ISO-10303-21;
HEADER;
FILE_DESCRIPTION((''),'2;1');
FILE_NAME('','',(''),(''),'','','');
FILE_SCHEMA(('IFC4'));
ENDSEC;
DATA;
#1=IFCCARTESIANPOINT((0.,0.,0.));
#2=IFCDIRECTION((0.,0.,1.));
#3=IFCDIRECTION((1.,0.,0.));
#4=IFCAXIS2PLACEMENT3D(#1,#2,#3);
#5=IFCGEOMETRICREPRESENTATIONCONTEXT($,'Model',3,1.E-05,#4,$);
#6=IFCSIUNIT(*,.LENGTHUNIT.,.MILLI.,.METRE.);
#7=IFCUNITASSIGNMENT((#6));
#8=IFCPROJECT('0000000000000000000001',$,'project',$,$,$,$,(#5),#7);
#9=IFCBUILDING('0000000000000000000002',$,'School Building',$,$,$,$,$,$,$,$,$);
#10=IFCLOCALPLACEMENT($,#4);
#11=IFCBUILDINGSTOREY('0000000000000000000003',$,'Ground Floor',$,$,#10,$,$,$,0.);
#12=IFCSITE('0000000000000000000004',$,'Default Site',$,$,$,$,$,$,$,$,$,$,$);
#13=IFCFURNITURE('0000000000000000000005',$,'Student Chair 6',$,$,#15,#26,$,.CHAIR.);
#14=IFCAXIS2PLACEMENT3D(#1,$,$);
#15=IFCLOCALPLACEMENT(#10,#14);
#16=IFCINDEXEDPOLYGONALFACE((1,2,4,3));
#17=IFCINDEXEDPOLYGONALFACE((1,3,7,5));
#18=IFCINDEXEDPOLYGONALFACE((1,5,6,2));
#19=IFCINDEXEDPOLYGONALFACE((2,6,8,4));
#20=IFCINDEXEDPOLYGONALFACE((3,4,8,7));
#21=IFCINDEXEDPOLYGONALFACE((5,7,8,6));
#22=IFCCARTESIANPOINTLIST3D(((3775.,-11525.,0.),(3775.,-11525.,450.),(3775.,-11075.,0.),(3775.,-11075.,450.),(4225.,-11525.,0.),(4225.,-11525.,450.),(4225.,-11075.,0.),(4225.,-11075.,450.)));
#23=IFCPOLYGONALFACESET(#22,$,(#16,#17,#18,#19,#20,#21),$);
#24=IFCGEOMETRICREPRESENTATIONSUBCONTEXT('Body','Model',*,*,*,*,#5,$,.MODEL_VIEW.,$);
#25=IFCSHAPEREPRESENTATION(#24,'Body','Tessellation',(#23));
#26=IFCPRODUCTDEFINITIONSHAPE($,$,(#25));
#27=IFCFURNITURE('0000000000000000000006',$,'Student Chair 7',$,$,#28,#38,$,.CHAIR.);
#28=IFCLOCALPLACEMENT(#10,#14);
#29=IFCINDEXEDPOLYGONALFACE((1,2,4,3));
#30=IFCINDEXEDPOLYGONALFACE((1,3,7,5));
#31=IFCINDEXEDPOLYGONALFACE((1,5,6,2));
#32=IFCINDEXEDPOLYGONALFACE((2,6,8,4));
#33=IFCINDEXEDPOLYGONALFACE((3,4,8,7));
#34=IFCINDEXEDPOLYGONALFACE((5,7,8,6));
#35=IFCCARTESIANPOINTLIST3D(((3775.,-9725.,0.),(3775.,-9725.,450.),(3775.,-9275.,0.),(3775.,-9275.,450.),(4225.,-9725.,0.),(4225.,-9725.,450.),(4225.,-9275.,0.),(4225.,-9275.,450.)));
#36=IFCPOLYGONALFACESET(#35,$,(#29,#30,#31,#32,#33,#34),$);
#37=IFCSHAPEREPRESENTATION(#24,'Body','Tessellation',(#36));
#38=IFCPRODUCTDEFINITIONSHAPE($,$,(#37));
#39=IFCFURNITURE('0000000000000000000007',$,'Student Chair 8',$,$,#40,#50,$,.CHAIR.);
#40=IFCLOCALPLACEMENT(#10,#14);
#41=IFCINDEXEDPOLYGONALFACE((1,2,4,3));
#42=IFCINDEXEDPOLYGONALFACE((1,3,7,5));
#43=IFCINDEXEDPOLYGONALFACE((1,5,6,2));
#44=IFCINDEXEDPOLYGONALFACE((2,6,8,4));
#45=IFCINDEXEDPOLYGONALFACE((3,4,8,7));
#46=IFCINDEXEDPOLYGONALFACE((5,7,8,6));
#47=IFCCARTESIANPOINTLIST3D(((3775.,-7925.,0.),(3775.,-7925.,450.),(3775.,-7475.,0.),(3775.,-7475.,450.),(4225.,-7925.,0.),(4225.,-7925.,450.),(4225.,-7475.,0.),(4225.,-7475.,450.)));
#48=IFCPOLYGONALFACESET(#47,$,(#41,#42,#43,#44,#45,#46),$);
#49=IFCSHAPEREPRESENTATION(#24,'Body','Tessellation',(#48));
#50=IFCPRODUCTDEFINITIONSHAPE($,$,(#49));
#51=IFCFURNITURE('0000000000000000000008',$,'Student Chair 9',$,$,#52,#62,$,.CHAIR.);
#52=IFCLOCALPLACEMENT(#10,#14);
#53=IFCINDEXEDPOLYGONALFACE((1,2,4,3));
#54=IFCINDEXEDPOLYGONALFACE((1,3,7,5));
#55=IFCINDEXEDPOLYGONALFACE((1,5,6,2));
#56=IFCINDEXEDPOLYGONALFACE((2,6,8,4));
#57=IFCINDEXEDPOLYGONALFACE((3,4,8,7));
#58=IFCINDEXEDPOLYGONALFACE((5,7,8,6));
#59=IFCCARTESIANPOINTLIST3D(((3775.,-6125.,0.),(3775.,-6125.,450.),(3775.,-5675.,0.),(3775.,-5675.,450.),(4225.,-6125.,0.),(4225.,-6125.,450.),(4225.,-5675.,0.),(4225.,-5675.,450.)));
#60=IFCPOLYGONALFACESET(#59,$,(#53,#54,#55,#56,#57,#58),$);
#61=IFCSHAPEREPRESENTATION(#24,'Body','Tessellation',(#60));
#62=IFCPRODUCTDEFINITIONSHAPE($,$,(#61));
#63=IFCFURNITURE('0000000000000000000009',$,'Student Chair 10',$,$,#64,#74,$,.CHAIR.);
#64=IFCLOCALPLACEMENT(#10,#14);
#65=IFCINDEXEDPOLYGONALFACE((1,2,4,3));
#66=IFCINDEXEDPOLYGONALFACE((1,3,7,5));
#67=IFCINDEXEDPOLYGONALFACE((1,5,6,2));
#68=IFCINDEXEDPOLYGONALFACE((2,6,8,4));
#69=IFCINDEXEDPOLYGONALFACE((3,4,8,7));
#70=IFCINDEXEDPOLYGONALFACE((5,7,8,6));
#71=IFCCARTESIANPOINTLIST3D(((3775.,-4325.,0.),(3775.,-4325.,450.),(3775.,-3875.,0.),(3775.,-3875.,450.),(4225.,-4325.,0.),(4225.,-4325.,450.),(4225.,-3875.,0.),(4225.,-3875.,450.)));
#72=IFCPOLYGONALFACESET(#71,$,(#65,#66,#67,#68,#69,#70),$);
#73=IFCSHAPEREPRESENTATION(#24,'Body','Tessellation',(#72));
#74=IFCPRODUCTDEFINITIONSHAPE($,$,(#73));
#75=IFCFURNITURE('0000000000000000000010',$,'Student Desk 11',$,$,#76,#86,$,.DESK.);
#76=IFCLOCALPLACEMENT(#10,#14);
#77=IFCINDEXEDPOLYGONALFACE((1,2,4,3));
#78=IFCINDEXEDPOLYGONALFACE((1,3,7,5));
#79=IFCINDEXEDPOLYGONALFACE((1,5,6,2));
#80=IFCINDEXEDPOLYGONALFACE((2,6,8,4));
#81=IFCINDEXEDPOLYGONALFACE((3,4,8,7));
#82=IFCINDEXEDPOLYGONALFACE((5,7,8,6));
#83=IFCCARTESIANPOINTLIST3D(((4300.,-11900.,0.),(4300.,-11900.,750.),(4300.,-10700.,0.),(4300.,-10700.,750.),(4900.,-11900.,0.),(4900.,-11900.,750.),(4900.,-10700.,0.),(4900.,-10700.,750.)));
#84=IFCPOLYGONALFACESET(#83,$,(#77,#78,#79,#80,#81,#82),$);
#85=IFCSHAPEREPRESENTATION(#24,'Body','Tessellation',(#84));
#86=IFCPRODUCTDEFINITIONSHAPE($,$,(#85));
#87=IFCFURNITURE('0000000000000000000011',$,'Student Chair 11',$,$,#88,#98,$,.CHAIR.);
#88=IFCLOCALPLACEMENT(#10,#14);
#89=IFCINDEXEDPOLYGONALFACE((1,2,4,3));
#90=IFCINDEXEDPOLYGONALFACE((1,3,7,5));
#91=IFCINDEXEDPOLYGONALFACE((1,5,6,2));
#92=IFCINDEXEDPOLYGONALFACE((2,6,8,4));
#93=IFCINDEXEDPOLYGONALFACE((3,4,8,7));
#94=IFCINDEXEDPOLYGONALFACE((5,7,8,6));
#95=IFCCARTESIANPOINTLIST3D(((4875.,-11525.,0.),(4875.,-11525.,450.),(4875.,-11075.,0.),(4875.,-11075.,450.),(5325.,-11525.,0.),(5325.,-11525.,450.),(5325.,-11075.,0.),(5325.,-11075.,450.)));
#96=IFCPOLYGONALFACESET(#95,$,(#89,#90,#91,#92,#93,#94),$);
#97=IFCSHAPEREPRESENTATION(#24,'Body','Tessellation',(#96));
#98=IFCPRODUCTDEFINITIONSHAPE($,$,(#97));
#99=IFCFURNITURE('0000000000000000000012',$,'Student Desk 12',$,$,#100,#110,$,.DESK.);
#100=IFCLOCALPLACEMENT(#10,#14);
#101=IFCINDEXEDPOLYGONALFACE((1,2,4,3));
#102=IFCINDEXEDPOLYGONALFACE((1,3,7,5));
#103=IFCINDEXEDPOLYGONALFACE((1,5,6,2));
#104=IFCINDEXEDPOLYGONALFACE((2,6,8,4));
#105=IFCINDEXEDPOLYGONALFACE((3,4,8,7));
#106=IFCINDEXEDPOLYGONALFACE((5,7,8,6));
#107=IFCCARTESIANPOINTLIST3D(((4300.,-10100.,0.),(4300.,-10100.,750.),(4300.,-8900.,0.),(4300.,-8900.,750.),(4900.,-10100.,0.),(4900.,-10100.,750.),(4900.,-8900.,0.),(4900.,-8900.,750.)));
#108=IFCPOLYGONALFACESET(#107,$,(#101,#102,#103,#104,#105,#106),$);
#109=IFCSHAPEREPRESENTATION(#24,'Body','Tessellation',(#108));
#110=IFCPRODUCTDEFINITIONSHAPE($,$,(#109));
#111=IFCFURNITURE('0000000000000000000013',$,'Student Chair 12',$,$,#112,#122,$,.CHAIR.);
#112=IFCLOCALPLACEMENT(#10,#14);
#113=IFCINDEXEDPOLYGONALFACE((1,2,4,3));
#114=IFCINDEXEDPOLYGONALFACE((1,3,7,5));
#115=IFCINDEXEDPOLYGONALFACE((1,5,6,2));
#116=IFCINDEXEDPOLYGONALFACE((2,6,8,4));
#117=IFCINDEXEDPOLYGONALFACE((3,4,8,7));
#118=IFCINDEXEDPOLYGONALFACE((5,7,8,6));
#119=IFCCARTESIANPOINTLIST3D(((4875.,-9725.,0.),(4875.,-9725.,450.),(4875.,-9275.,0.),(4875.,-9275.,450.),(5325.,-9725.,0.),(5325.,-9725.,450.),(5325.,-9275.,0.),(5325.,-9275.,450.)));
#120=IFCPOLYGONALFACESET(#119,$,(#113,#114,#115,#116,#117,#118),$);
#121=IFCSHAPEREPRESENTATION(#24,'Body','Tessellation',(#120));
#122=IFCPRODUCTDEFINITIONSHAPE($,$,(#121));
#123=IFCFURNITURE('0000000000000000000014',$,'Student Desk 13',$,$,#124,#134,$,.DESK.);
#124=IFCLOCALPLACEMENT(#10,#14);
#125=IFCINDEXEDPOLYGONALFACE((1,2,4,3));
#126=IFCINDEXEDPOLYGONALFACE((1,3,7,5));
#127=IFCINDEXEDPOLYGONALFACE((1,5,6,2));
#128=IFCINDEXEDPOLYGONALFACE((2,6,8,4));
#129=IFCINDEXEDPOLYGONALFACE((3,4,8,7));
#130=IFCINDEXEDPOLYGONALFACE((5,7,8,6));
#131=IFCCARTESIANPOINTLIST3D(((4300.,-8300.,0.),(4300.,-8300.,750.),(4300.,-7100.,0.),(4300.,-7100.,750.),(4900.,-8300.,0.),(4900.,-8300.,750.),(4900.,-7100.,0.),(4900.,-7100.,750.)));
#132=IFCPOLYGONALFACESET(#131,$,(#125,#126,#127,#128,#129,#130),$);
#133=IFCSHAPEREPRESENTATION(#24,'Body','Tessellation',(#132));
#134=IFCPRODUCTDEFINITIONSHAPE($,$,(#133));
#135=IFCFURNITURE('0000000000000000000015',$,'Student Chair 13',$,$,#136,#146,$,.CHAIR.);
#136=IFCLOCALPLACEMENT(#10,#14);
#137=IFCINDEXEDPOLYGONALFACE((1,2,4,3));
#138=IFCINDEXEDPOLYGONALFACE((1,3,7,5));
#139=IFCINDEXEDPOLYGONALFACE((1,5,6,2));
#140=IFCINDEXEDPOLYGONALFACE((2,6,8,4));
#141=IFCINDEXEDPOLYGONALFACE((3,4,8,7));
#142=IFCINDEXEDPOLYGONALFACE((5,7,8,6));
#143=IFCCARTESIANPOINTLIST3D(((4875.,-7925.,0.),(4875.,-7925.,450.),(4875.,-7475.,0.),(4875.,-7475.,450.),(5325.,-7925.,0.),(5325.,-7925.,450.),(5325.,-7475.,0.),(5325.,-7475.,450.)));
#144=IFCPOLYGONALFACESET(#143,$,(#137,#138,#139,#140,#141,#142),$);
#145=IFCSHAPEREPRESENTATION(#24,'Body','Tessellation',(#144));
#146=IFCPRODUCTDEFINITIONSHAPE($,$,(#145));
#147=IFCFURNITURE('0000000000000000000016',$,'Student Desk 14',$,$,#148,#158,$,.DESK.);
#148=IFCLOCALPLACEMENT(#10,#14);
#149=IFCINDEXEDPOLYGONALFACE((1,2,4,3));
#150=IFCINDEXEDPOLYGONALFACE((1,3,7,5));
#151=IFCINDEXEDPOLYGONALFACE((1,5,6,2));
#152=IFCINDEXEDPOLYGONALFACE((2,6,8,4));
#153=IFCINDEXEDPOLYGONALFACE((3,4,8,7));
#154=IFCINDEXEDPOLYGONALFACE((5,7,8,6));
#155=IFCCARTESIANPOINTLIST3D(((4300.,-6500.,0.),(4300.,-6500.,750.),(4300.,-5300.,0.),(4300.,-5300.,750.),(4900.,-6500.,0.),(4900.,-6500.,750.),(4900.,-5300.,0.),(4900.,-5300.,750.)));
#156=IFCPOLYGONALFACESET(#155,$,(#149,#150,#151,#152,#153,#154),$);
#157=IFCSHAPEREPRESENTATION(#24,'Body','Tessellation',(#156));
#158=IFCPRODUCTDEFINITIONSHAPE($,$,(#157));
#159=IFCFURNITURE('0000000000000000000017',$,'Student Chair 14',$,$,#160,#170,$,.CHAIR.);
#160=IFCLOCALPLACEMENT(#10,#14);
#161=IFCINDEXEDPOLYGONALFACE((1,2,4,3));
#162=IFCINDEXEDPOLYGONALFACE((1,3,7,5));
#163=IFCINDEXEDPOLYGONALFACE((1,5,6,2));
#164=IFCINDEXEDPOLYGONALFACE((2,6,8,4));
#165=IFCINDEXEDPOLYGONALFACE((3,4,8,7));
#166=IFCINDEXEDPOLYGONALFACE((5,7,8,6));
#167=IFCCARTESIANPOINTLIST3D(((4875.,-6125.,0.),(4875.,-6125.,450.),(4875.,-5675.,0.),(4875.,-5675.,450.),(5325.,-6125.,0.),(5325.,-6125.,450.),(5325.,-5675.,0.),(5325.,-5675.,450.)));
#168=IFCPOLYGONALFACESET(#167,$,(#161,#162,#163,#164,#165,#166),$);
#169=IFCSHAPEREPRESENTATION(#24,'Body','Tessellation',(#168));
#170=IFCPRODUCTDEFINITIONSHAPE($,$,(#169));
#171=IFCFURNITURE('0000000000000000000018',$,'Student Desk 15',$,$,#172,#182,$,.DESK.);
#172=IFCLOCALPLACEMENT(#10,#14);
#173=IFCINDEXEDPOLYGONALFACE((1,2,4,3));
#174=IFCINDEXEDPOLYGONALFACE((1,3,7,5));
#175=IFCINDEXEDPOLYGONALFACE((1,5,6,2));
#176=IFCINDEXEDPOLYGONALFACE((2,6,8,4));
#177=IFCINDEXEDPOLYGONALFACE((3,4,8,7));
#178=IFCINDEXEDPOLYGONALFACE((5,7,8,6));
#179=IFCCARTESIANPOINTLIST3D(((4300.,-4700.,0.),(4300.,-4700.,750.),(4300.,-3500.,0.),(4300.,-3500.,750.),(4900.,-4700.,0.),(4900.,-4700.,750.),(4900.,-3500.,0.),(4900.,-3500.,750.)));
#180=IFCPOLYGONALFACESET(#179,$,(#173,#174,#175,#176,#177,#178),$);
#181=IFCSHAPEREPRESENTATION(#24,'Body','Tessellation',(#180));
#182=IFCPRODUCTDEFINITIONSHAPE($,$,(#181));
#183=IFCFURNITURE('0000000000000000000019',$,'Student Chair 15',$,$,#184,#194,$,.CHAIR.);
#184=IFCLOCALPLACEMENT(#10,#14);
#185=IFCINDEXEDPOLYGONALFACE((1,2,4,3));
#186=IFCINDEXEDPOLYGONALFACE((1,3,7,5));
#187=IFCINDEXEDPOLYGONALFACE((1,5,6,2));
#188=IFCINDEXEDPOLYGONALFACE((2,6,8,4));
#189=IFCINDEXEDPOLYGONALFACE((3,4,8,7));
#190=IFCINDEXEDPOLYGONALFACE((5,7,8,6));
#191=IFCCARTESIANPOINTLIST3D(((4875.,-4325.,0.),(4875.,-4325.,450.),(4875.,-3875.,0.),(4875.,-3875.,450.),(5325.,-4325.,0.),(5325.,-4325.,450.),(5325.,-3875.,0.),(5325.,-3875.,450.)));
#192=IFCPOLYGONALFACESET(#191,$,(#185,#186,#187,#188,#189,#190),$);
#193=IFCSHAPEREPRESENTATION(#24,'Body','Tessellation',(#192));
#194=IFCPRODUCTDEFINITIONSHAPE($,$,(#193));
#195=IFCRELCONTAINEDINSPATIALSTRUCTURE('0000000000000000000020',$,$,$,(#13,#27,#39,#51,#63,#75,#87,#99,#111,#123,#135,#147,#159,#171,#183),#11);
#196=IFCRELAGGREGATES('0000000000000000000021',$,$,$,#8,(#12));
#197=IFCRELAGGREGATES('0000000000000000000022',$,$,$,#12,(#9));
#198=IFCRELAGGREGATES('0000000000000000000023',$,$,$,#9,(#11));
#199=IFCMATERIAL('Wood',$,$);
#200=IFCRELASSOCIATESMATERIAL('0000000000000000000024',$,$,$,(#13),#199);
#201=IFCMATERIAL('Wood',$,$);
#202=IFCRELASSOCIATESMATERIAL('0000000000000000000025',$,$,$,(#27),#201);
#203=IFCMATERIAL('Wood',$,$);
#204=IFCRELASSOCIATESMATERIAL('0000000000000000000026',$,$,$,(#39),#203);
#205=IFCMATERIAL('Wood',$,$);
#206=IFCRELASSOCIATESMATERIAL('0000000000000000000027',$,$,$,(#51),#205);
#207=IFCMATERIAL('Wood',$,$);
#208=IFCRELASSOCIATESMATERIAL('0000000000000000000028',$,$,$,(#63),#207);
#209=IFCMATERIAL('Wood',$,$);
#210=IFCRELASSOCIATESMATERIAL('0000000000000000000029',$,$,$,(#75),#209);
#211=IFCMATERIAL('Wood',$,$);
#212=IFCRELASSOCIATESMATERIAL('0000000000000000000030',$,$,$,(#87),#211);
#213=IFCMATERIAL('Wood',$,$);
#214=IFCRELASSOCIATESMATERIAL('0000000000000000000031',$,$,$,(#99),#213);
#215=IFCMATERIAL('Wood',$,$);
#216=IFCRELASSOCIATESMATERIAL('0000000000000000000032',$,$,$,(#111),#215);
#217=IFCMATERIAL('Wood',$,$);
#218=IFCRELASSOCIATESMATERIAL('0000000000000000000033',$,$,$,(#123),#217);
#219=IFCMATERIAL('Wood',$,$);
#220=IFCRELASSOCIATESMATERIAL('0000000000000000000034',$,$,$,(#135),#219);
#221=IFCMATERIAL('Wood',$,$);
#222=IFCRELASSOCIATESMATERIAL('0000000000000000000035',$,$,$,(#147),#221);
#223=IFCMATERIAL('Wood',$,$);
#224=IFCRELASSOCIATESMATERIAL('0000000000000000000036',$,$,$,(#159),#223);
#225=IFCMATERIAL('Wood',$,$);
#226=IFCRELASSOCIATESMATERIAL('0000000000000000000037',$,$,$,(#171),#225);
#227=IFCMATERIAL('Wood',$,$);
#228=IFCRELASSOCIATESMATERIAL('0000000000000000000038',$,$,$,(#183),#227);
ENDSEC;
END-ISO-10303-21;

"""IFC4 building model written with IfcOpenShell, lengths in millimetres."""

from ifc_helpers import new_model, si_unit, frame, origin_with_axes, origin_2d, place, context, subcontext, project, spatial, rectangle, extrude, material, element, save


model = new_model("IFC4")

# Units and contexts
model_context = context("Model", 3, precision=1e-05, world=origin_with_axes())
body_context = subcontext(model_context, "Body", "Model", "MODEL_VIEW")
ifc_project = project(units=[si_unit("LENGTHUNIT", "METRE", prefix="MILLI")], contexts=[model_context])

# Site, building, storey
site = spatial("IfcSite", under=ifc_project, Name="Default Site")
building = spatial("IfcBuilding", under=site, Name="School Building")
storey_placement = place(None, origin_with_axes())
storey = spatial("IfcBuildingStorey", under=building, at=storey_placement, Name="Ground Floor", Elevation=0.0)

# Furniture
ifc_material_1 = material(Name="Wood")
furniture_1_placement = place(storey_placement, frame((4000.0, -11300.0, 0.0), z_axis=(0.0, 0.0, 1.0), x_axis=(1.0, 0.0, 0.0)))
element("IfcFurniture", 1, at=furniture_1_placement, inside=storey, material=ifc_material_1, Name="Student Chair 6", PredefinedType="CHAIR", context=body_context, shape_type="SweptSolid", body=[
    extrude(rectangle(XDim=450.0, YDim=450.0, at=origin_2d()), origin_with_axes(), (0.0, 0.0, 1.0), 450.0),
])
ifc_material_2 = material(Name="Wood")
furniture_2_placement = place(storey_placement, frame((4000.0, -9500.0, 0.0), z_axis=(0.0, 0.0, 1.0), x_axis=(1.0, 0.0, 0.0)))
element("IfcFurniture", 2, at=furniture_2_placement, inside=storey, material=ifc_material_2, Name="Student Chair 7", PredefinedType="CHAIR", context=body_context, shape_type="SweptSolid", body=[
    extrude(rectangle(XDim=450.0, YDim=450.0, at=origin_2d()), origin_with_axes(), (0.0, 0.0, 1.0), 450.0),
])
ifc_material_3 = material(Name="Wood")
furniture_3_placement = place(storey_placement, frame((4000.0, -7700.0, 0.0), z_axis=(0.0, 0.0, 1.0), x_axis=(1.0, 0.0, 0.0)))
element("IfcFurniture", 3, at=furniture_3_placement, inside=storey, material=ifc_material_3, Name="Student Chair 8", PredefinedType="CHAIR", context=body_context, shape_type="SweptSolid", body=[
    extrude(rectangle(XDim=450.0, YDim=450.0, at=origin_2d()), origin_with_axes(), (0.0, 0.0, 1.0), 450.0),
])
ifc_material_4 = material(Name="Wood")
furniture_4_placement = place(storey_placement, frame((4000.0, -5900.0, 0.0), z_axis=(0.0, 0.0, 1.0), x_axis=(1.0, 0.0, 0.0)))
element("IfcFurniture", 4, at=furniture_4_placement, inside=storey, material=ifc_material_4, Name="Student Chair 9", PredefinedType="CHAIR", context=body_context, shape_type="SweptSolid", body=[
    extrude(rectangle(XDim=450.0, YDim=450.0, at=origin_2d()), origin_with_axes(), (0.0, 0.0, 1.0), 450.0),
])
ifc_material_5 = material(Name="Wood")
furniture_5_placement = place(storey_placement, frame((4000.0, -4100.0, 0.0), z_axis=(0.0, 0.0, 1.0), x_axis=(1.0, 0.0, 0.0)))
element("IfcFurniture", 5, at=furniture_5_placement, inside=storey, material=ifc_material_5, Name="Student Chair 10", PredefinedType="CHAIR", context=body_context, shape_type="SweptSolid", body=[
    extrude(rectangle(XDim=450.0, YDim=450.0, at=origin_2d()), origin_with_axes(), (0.0, 0.0, 1.0), 450.0),
])
ifc_material_6 = material(Name="Wood")
furniture_6_placement = place(storey_placement, frame((4600.0, -11300.0, 0.0), z_axis=(0.0, 0.0, 1.0), x_axis=(0.0, 1.0, 0.0)))
element("IfcFurniture", 6, at=furniture_6_placement, inside=storey, material=ifc_material_6, Name="Student Desk 11", PredefinedType="DESK", context=body_context, shape_type="SweptSolid", body=[
    extrude(rectangle(XDim=1200.0, YDim=600.0, at=origin_2d()), origin_with_axes(), (0.0, 0.0, 1.0), 750.0),
])
ifc_material_7 = material(Name="Wood")
furniture_7_placement = place(storey_placement, frame((5100.0, -11300.0, 0.0), z_axis=(0.0, 0.0, 1.0), x_axis=(1.0, 0.0, 0.0)))
element("IfcFurniture", 7, at=furniture_7_placement, inside=storey, material=ifc_material_7, Name="Student Chair 11", PredefinedType="CHAIR", context=body_context, shape_type="SweptSolid", body=[
    extrude(rectangle(XDim=450.0, YDim=450.0, at=origin_2d()), origin_with_axes(), (0.0, 0.0, 1.0), 450.0),
])
ifc_material_8 = material(Name="Wood")
furniture_8_placement = place(storey_placement, frame((4600.0, -9500.0, 0.0), z_axis=(0.0, 0.0, 1.0), x_axis=(0.0, 1.0, 0.0)))
element("IfcFurniture", 8, at=furniture_8_placement, inside=storey, material=ifc_material_8, Name="Student Desk 12", PredefinedType="DESK", context=body_context, shape_type="SweptSolid", body=[
    extrude(rectangle(XDim=1200.0, YDim=600.0, at=origin_2d()), origin_with_axes(), (0.0, 0.0, 1.0), 750.0),
])
ifc_material_9 = material(Name="Wood")
furniture_9_placement = place(storey_placement, frame((5100.0, -9500.0, 0.0), z_axis=(0.0, 0.0, 1.0), x_axis=(1.0, 0.0, 0.0)))
element("IfcFurniture", 9, at=furniture_9_placement, inside=storey, material=ifc_material_9, Name="Student Chair 12", PredefinedType="CHAIR", context=body_context, shape_type="SweptSolid", body=[
    extrude(rectangle(XDim=450.0, YDim=450.0, at=origin_2d()), origin_with_axes(), (0.0, 0.0, 1.0), 450.0),
])
ifc_material_10 = material(Name="Wood")
furniture_10_placement = place(storey_placement, frame((4600.0, -7700.0, 0.0), z_axis=(0.0, 0.0, 1.0), x_axis=(0.0, 1.0, 0.0)))
element("IfcFurniture", 10, at=furniture_10_placement, inside=storey, material=ifc_material_10, Name="Student Desk 13", PredefinedType="DESK", context=body_context, shape_type="SweptSolid", body=[
    extrude(rectangle(XDim=1200.0, YDim=600.0, at=origin_2d()), origin_with_axes(), (0.0, 0.0, 1.0), 750.0),
])
ifc_material_11 = material(Name="Wood")
furniture_11_placement = place(storey_placement, frame((5100.0, -7700.0, 0.0), z_axis=(0.0, 0.0, 1.0), x_axis=(1.0, 0.0, 0.0)))
element("IfcFurniture", 11, at=furniture_11_placement, inside=storey, material=ifc_material_11, Name="Student Chair 13", PredefinedType="CHAIR", context=body_context, shape_type="SweptSolid", body=[
    extrude(rectangle(XDim=450.0, YDim=450.0, at=origin_2d()), origin_with_axes(), (0.0, 0.0, 1.0), 450.0),
])
ifc_material_12 = material(Name="Wood")
furniture_12_placement = place(storey_placement, frame((4600.0, -5900.0, 0.0), z_axis=(0.0, 0.0, 1.0), x_axis=(0.0, 1.0, 0.0)))
element("IfcFurniture", 12, at=furniture_12_placement, inside=storey, material=ifc_material_12, Name="Student Desk 14", PredefinedType="DESK", context=body_context, shape_type="SweptSolid", body=[
    extrude(rectangle(XDim=1200.0, YDim=600.0, at=origin_2d()), origin_with_axes(), (0.0, 0.0, 1.0), 750.0),
])
ifc_material_13 = material(Name="Wood")
furniture_13_placement = place(storey_placement, frame((5100.0, -5900.0, 0.0), z_axis=(0.0, 0.0, 1.0), x_axis=(1.0, 0.0, 0.0)))
element("IfcFurniture", 13, at=furniture_13_placement, inside=storey, material=ifc_material_13, Name="Student Chair 14", PredefinedType="CHAIR", context=body_context, shape_type="SweptSolid", body=[
    extrude(rectangle(XDim=450.0, YDim=450.0, at=origin_2d()), origin_with_axes(), (0.0, 0.0, 1.0), 450.0),
])
ifc_material_14 = material(Name="Wood")
furniture_14_placement = place(storey_placement, frame((4600.0, -4100.0, 0.0), z_axis=(0.0, 0.0, 1.0), x_axis=(0.0, 1.0, 0.0)))
element("IfcFurniture", 14, at=furniture_14_placement, inside=storey, material=ifc_material_14, Name="Student Desk 15", PredefinedType="DESK", context=body_context, shape_type="SweptSolid", body=[
    extrude(rectangle(XDim=1200.0, YDim=600.0, at=origin_2d()), origin_with_axes(), (0.0, 0.0, 1.0), 750.0),
])
ifc_material_15 = material(Name="Wood")
furniture_15_placement = place(storey_placement, frame((5100.0, -4100.0, 0.0), z_axis=(0.0, 0.0, 1.0), x_axis=(1.0, 0.0, 0.0)))
element("IfcFurniture", 15, at=furniture_15_placement, inside=storey, material=ifc_material_15, Name="Student Chair 15", PredefinedType="CHAIR", context=body_context, shape_type="SweptSolid", body=[
    extrude(rectangle(XDim=450.0, YDim=450.0, at=origin_2d()), origin_with_axes(), (0.0, 0.0, 1.0), 450.0),
])

save(model, "model.ifc")
